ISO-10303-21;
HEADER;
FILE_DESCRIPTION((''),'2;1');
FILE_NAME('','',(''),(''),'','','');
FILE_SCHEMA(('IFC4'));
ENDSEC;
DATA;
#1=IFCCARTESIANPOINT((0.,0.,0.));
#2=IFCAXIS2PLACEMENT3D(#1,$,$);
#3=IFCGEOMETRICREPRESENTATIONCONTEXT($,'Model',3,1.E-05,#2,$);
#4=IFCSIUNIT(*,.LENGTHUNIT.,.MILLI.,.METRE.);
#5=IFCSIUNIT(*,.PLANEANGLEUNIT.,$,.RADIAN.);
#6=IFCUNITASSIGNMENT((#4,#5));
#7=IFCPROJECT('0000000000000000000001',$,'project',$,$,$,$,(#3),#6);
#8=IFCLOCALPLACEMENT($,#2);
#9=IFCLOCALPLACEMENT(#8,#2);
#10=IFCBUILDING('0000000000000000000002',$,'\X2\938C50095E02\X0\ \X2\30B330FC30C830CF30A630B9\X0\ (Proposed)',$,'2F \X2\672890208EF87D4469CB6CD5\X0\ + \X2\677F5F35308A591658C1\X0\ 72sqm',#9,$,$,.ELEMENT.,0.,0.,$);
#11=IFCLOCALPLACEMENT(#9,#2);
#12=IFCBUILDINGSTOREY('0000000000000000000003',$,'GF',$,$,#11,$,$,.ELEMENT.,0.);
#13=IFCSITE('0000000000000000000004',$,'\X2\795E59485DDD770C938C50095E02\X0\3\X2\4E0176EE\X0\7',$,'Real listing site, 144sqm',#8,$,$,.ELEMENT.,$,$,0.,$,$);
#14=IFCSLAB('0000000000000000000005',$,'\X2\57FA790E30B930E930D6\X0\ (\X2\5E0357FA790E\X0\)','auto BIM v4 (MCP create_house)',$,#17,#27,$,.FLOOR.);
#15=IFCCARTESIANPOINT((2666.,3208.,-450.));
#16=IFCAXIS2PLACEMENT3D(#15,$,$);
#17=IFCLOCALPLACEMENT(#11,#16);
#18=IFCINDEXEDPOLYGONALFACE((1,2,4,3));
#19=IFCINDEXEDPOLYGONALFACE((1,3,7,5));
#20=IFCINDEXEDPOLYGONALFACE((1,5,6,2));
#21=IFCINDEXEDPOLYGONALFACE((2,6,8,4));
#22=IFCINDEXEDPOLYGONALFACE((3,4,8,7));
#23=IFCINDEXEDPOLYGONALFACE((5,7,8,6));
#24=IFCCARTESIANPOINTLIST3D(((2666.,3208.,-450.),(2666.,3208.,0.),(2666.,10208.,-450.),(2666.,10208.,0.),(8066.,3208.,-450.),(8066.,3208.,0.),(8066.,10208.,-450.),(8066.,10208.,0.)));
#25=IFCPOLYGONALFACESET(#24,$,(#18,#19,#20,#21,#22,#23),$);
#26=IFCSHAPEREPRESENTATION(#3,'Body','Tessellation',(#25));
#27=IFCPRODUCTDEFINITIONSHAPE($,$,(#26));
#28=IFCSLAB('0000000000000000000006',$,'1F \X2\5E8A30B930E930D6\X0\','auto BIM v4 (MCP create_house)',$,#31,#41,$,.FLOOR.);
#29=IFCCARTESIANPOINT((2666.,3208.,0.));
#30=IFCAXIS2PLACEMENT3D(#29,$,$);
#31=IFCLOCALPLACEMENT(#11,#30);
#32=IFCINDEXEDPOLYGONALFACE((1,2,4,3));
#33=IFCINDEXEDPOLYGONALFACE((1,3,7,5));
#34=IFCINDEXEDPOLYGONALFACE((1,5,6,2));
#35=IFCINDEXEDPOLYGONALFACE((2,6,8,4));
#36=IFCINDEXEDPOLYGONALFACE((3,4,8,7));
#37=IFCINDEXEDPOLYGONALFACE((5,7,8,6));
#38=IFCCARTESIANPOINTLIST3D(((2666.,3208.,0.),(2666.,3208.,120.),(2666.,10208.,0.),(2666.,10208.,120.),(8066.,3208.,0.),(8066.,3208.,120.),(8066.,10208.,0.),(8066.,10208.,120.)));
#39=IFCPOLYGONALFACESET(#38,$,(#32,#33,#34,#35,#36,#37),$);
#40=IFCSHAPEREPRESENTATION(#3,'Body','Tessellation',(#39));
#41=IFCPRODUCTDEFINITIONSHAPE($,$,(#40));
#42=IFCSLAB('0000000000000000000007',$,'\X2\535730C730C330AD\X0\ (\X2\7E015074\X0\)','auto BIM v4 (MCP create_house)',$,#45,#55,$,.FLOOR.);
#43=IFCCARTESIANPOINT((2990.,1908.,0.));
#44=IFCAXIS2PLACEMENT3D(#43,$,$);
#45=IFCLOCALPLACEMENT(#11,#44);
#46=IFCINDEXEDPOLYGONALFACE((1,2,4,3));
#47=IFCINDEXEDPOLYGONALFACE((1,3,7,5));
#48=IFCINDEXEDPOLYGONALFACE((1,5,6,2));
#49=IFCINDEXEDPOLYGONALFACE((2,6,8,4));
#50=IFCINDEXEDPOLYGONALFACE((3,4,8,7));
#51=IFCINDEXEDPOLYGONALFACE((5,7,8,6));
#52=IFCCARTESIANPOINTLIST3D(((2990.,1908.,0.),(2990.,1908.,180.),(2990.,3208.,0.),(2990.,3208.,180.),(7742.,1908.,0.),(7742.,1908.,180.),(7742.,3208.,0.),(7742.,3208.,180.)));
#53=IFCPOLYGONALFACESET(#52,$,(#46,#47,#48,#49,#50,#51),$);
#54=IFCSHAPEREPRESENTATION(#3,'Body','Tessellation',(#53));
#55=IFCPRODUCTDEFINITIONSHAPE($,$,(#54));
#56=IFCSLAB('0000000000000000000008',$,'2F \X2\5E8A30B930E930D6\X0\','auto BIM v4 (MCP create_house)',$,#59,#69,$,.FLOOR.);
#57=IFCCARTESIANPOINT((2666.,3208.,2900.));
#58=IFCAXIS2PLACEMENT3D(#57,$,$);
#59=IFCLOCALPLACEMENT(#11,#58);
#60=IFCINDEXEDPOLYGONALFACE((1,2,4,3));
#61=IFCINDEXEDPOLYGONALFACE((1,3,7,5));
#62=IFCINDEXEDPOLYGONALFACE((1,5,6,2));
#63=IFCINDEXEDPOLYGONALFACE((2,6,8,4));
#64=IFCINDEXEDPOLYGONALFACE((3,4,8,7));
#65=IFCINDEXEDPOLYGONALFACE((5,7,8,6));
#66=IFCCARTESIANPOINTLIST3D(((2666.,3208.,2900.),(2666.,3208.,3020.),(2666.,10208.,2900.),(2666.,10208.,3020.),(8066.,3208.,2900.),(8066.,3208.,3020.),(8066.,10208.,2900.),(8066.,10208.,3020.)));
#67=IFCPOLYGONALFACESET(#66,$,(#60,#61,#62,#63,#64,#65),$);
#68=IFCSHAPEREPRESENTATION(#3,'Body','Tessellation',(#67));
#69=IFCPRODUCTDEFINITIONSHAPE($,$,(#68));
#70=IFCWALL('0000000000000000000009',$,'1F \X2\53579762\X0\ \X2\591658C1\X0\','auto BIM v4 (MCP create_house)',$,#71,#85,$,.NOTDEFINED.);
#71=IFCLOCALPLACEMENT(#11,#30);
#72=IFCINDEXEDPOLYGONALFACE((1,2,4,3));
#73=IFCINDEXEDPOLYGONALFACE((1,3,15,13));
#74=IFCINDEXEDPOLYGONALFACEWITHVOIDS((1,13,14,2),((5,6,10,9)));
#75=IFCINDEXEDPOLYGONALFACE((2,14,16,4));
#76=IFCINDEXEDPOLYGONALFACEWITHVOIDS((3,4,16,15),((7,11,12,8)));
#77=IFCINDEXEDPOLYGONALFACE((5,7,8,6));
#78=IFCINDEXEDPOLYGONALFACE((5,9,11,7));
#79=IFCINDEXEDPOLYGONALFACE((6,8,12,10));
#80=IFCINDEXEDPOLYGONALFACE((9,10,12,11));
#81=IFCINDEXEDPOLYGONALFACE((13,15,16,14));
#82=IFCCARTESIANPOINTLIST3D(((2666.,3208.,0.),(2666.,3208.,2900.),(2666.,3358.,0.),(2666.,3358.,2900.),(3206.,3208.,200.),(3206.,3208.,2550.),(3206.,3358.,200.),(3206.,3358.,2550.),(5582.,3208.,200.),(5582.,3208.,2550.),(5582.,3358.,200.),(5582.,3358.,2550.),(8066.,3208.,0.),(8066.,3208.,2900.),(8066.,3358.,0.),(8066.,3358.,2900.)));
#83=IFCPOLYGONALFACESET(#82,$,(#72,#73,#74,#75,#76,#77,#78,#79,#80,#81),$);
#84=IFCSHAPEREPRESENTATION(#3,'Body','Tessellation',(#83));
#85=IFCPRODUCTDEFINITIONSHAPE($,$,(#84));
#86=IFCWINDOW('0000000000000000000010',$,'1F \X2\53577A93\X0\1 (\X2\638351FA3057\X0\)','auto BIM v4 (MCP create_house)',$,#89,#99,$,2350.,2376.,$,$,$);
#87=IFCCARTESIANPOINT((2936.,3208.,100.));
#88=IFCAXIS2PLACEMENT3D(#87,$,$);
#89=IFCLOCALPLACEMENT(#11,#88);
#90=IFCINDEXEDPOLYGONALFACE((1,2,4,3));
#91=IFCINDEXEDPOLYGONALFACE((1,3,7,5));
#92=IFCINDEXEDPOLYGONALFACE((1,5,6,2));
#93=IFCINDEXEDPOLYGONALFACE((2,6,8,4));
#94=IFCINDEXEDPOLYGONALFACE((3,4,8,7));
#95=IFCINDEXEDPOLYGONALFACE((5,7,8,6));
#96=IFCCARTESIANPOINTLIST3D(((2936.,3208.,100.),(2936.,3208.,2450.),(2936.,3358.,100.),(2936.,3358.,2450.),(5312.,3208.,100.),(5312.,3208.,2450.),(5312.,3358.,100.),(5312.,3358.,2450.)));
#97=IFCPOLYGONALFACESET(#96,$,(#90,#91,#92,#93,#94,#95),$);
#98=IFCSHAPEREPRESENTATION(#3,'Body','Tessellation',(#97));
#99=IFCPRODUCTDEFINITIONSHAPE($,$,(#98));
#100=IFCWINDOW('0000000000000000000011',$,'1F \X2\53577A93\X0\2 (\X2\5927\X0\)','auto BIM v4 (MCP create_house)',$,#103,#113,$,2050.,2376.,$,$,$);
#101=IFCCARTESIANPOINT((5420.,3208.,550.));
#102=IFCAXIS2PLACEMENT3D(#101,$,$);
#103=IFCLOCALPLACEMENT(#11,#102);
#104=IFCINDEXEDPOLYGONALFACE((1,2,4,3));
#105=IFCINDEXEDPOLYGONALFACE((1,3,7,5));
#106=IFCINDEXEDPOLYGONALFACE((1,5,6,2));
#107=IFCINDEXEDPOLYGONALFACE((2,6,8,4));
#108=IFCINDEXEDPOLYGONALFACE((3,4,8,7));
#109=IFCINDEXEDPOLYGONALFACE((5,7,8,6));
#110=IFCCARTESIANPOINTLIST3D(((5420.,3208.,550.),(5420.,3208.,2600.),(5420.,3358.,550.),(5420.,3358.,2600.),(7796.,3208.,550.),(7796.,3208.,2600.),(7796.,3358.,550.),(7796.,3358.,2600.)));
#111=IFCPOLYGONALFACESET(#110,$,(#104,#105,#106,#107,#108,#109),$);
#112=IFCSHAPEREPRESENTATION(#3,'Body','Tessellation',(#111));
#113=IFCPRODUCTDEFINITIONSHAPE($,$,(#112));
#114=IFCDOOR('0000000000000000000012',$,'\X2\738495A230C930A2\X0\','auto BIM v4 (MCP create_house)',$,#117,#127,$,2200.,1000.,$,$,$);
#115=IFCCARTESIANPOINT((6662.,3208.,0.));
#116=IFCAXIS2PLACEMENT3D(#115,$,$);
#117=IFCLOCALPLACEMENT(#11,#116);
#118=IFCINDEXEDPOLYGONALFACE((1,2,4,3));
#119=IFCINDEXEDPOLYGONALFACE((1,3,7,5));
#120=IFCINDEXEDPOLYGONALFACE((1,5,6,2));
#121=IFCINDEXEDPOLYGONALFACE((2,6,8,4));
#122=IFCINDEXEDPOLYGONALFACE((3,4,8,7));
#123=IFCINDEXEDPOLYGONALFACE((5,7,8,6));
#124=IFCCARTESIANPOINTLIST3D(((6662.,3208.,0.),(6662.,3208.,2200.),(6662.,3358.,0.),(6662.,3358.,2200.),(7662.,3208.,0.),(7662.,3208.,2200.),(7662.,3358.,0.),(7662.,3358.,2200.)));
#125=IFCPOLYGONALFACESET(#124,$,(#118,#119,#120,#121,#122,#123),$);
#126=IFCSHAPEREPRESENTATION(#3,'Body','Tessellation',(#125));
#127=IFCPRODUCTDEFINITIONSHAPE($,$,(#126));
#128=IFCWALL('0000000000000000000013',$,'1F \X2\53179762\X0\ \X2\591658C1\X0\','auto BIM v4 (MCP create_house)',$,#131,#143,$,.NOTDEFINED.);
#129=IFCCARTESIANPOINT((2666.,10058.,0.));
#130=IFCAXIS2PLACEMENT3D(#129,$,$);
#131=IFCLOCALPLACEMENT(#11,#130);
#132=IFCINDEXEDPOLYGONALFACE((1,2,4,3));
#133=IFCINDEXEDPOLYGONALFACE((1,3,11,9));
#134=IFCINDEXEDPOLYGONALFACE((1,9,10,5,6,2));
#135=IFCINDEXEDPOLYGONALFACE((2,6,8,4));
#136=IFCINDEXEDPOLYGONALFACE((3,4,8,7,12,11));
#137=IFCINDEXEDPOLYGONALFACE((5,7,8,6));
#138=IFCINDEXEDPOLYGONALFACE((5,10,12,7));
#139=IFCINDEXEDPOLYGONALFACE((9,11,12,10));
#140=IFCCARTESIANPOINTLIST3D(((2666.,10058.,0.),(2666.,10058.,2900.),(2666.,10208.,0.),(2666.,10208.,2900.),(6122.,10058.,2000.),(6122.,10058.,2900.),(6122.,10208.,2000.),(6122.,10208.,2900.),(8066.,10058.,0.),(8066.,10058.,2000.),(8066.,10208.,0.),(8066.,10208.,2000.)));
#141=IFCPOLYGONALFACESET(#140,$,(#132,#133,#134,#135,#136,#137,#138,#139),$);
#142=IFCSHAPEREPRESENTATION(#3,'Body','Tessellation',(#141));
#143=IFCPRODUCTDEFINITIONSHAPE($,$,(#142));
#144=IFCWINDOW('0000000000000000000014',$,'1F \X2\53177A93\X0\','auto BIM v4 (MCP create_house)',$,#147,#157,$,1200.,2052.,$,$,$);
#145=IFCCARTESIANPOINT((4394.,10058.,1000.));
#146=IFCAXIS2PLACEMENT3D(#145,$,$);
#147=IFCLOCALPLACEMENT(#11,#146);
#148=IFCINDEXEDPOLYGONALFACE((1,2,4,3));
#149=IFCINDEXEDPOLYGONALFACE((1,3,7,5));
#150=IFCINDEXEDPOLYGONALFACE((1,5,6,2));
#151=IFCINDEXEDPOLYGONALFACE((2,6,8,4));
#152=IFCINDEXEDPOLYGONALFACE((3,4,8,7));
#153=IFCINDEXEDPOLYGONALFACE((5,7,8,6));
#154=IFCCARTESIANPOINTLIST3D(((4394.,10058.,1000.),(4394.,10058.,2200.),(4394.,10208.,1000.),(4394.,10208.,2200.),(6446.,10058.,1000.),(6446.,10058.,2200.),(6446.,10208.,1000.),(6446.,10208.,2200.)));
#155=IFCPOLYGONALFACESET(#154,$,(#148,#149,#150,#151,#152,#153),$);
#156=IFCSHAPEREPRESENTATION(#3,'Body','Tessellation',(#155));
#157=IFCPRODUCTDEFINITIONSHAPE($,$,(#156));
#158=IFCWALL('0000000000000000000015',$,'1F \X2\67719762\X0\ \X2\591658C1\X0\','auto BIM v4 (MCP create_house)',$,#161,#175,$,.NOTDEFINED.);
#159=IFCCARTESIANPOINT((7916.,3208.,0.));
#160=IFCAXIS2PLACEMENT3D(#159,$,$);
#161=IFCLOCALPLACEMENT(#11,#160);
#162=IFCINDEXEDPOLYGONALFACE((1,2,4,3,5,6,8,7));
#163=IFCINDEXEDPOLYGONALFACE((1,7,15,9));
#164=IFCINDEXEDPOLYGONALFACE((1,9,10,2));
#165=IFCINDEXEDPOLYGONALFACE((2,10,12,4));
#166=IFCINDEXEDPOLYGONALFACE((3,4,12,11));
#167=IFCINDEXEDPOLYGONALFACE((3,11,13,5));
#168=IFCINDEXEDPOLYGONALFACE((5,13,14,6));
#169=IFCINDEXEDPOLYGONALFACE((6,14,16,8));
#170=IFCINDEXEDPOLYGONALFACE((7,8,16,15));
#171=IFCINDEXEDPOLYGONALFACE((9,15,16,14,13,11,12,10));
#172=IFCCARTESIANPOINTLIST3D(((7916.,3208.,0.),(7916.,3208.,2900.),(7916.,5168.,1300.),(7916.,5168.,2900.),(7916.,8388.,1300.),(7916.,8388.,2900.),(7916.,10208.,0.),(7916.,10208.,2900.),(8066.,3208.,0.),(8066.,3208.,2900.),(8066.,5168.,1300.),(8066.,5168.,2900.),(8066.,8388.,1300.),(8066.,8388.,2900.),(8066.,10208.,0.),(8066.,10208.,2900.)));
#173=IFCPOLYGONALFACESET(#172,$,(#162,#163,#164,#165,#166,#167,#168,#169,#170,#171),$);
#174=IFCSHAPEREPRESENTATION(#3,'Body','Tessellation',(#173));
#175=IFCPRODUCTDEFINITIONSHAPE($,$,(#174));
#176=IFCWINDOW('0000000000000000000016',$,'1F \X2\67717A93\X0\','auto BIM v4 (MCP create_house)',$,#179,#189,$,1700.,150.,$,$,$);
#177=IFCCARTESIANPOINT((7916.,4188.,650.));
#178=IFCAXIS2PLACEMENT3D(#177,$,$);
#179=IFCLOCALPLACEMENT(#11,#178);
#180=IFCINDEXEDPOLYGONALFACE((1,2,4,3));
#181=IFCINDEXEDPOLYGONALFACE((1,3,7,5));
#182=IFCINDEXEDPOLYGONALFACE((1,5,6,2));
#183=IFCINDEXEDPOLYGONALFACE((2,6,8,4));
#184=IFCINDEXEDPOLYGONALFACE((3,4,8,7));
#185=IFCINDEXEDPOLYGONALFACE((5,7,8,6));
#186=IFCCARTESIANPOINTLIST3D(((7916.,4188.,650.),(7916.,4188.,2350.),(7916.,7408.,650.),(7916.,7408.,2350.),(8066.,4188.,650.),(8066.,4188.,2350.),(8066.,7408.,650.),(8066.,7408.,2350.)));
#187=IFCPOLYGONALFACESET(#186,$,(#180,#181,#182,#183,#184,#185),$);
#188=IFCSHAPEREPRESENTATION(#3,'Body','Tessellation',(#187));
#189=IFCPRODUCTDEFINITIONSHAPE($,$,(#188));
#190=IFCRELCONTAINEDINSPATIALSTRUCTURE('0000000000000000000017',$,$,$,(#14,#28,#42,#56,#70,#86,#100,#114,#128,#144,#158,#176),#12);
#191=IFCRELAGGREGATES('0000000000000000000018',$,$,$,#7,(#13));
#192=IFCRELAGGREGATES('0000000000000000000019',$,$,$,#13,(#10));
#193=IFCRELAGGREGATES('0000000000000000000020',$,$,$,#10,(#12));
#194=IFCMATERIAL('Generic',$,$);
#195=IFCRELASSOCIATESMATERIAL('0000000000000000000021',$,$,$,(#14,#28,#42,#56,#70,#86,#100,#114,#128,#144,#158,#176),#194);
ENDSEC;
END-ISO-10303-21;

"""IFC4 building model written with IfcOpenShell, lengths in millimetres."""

from ifc_helpers import new_model, si_unit, frame, frame_2d, origin, place, context, project, spatial, rectangle, extrude, material, element, fill, save


model = new_model("IFC4")

# Units and contexts
model_context = context("Model", 3, precision=1e-05, world=origin())
ifc_project = project(units=[si_unit("LENGTHUNIT", "METRE", prefix="MILLI"), si_unit("PLANEANGLEUNIT", "RADIAN")], contexts=[model_context])

# Site, building, storey
site_placement = place(None, origin())
site = spatial("IfcSite", under=ifc_project, at=site_placement, Name="神奈川県鎌倉市3丁目7", ObjectType="Real listing site, 144sqm", CompositionType="ELEMENT", RefElevation=0.0)
building_placement = place(site_placement, origin())
building = spatial("IfcBuilding", under=site, at=building_placement, Name="鎌倉市 コートハウス (Proposed)", ObjectType="2F 木造軸組構法 + 板張り外壁 72sqm", CompositionType="ELEMENT", ElevationOfRefHeight=0.0, ElevationOfTerrain=0.0)
storey_placement = place(building_placement, origin())
storey = spatial("IfcBuildingStorey", under=building, at=storey_placement, Name="GF", CompositionType="ELEMENT", Elevation=0.0)

# Slabs
ifc_material = material(Name="Generic")
slab_1_placement = place(storey_placement, frame((2666.0, 3208.0, -450.0)))
element("IfcSlab", 1, at=slab_1_placement, inside=storey, material=ifc_material, Name="基礎スラブ (布基礎)", Description="auto BIM v4 (MCP create_house)", PredefinedType="FLOOR", context=model_context, shape_type="SweptSolid", body=[
    extrude(rectangle(XDim=5400.0, YDim=7000.0, at=frame_2d((2700.0, 3500.0))), frame((2666.0, 3208.0, -450.0)), (0.0, 0.0, 1.0), 450.0),
])
slab_2_placement = place(storey_placement, frame((2666.0, 3208.0, 0.0)))
element("IfcSlab", 2, at=slab_2_placement, inside=storey, material=ifc_material, Name="1F 床スラブ", Description="auto BIM v4 (MCP create_house)", PredefinedType="FLOOR", context=model_context, shape_type="SweptSolid", body=[
    extrude(rectangle(XDim=5400.0, YDim=7000.0, at=frame_2d((2700.0, 3500.0))), frame((2666.0, 3208.0, 0.0)), (0.0, 0.0, 1.0), 120.0),
])
slab_3_placement = place(storey_placement, frame((2990.0, 1908.0, 0.0)))
element("IfcSlab", 3, at=slab_3_placement, inside=storey, material=ifc_material, Name="南デッキ (縁側)", Description="auto BIM v4 (MCP create_house)", PredefinedType="FLOOR", context=model_context, shape_type="SweptSolid", body=[
    extrude(rectangle(XDim=4752.0, YDim=1300.0, at=frame_2d((2376.0, 650.0))), frame((2990.0, 1908.0, 0.0)), (0.0, 0.0, 1.0), 180.0),
])
slab_4_placement = place(storey_placement, frame((2666.0, 3208.0, 2900.0)))
element("IfcSlab", 4, at=slab_4_placement, inside=storey, material=ifc_material, Name="2F 床スラブ", Description="auto BIM v4 (MCP create_house)", PredefinedType="FLOOR", context=model_context, shape_type="SweptSolid", body=[
    extrude(rectangle(XDim=5400.0, YDim=7000.0, at=frame_2d((2700.0, 3500.0))), frame((2666.0, 3208.0, 2900.0)), (0.0, 0.0, 1.0), 120.0),
])

# Wall, openings, windows, door
wall_1_placement = place(storey_placement, frame((2666.0, 3208.0, 0.0)))
wall_1 = element("IfcWall", 5, at=wall_1_placement, inside=storey, material=ifc_material, Name="1F 南面 外壁", Description="auto BIM v4 (MCP create_house)", PredefinedType="NOTDEFINED", context=model_context, shape_type="SweptSolid", body=[
    extrude(rectangle(XDim=5400.0, YDim=150.0, at=frame_2d((2700.0, 75.0))), frame((2666.0, 3208.0, 0.0)), (0.0, 0.0, 1.0), 2900.0),
])
opening_1_placement = place(storey_placement, frame((2936.0, 3208.0, 100.0)))
opening_1 = element("IfcOpeningElement", 6, at=opening_1_placement, cuts=wall_1, PredefinedType="NOTDEFINED", context=model_context, shape_type="SweptSolid", body=[
    extrude(rectangle(XDim=2376.0, YDim=150.0, at=frame_2d((1188.0, 75.0))), frame((2936.0, 3208.0, 100.0)), (0.0, 0.0, 1.0), 2350.0),
])
opening_2_placement = place(storey_placement, frame((5420.0, 3208.0, 550.0)))
opening_2 = element("IfcOpeningElement", 7, at=opening_2_placement, cuts=wall_1, PredefinedType="NOTDEFINED", context=model_context, shape_type="SweptSolid", body=[
    extrude(rectangle(XDim=2376.0, YDim=150.0, at=frame_2d((1188.0, 75.0))), frame((5420.0, 3208.0, 550.0)), (0.0, 0.0, 1.0), 2050.0),
])
opening_3_placement = place(storey_placement, frame((6662.0, 3208.0, 0.0)))
opening_3 = element("IfcOpeningElement", 8, at=opening_3_placement, cuts=wall_1, PredefinedType="NOTDEFINED", context=model_context, shape_type="SweptSolid", body=[
    extrude(rectangle(XDim=1000.0, YDim=150.0, at=frame_2d((500.0, 75.0))), frame((6662.0, 3208.0, 0.0)), (0.0, 0.0, 1.0), 2200.0),
])
window_1_placement = place(storey_placement, frame((2936.0, 3208.0, 100.0)))
window_1 = element("IfcWindow", 9, at=window_1_placement, inside=storey, material=ifc_material, Name="1F 南窓1 (掃出し)", Description="auto BIM v4 (MCP create_house)", OverallHeight=2350.0, OverallWidth=2376.0, context=model_context, shape_type="SweptSolid", body=[
    extrude(rectangle(XDim=2376.0, YDim=150.0, at=frame_2d((1188.0, 75.0))), frame((2936.0, 3208.0, 100.0)), (0.0, 0.0, 1.0), 2350.0),
])
fill(opening_1, window_1)
window_2_placement = place(storey_placement, frame((5420.0, 3208.0, 550.0)))
window_2 = element("IfcWindow", 10, at=window_2_placement, inside=storey, material=ifc_material, Name="1F 南窓2 (大)", Description="auto BIM v4 (MCP create_house)", OverallHeight=2050.0, OverallWidth=2376.0, context=model_context, shape_type="SweptSolid", body=[
    extrude(rectangle(XDim=2376.0, YDim=150.0, at=frame_2d((1188.0, 75.0))), frame((5420.0, 3208.0, 550.0)), (0.0, 0.0, 1.0), 2050.0),
])
fill(opening_2, window_2)
door_1_placement = place(storey_placement, frame((6662.0, 3208.0, 0.0)))
door_1 = element("IfcDoor", 11, at=door_1_placement, inside=storey, material=ifc_material, Name="玄関ドア", Description="auto BIM v4 (MCP create_house)", OverallHeight=2200.0, OverallWidth=1000.0, context=model_context, shape_type="SweptSolid", body=[
    extrude(rectangle(XDim=1000.0, YDim=150.0, at=frame_2d((500.0, 75.0))), frame((6662.0, 3208.0, 0.0)), (0.0, 0.0, 1.0), 2200.0),
])
fill(opening_3, door_1)

# Walls, openings, windows
wall_2_placement = place(storey_placement, frame((2666.0, 10058.0, 0.0)))
wall_2 = element("IfcWall", 12, at=wall_2_placement, inside=storey, material=ifc_material, Name="1F 北面 外壁", Description="auto BIM v4 (MCP create_house)", PredefinedType="NOTDEFINED", context=model_context, shape_type="SweptSolid", body=[
    extrude(rectangle(XDim=5400.0, YDim=150.0, at=frame_2d((2700.0, 75.0))), frame((2666.0, 10058.0, 0.0)), (0.0, 0.0, 1.0), 2900.0),
])
opening_4_placement = place(storey_placement, frame((4394.0, 10058.0, 1000.0)))
opening_4 = element("IfcOpeningElement", 13, at=opening_4_placement, cuts=wall_2, PredefinedType="NOTDEFINED", context=model_context, shape_type="SweptSolid", body=[
    extrude(rectangle(XDim=2052.0, YDim=150.0, at=frame_2d((1026.0, 75.0))), frame((4394.0, 10058.0, 1000.0)), (0.0, 0.0, 1.0), 1200.0),
])
window_3_placement = place(storey_placement, frame((4394.0, 10058.0, 1000.0)))
window_3 = element("IfcWindow", 14, at=window_3_placement, inside=storey, material=ifc_material, Name="1F 北窓", Description="auto BIM v4 (MCP create_house)", OverallHeight=1200.0, OverallWidth=2052.0, context=model_context, shape_type="SweptSolid", body=[
    extrude(rectangle(XDim=2052.0, YDim=150.0, at=frame_2d((1026.0, 75.0))), frame((4394.0, 10058.0, 1000.0)), (0.0, 0.0, 1.0), 1200.0),
])
fill(opening_4, window_3)
wall_3_placement = place(storey_placement, frame((7916.0, 3208.0, 0.0)))
wall_3 = element("IfcWall", 15, at=wall_3_placement, inside=storey, material=ifc_material, Name="1F 東面 外壁", Description="auto BIM v4 (MCP create_house)", PredefinedType="NOTDEFINED", context=model_context, shape_type="SweptSolid", body=[
    extrude(rectangle(XDim=150.0, YDim=7000.0, at=frame_2d((75.0, 3500.0))), frame((7916.0, 3208.0, 0.0)), (0.0, 0.0, 1.0), 2900.0),
])
opening_5_placement = place(storey_placement, frame((7916.0, 4188.0, 650.0)))
opening_5 = element("IfcOpeningElement", 16, at=opening_5_placement, cuts=wall_3, PredefinedType="NOTDEFINED", context=model_context, shape_type="SweptSolid", body=[
    extrude(rectangle(XDim=150.0, YDim=3220.0, at=frame_2d((75.0, 1610.0))), frame((7916.0, 4188.0, 650.0)), (0.0, 0.0, 1.0), 1700.0),
])
window_4_placement = place(storey_placement, frame((7916.0, 4188.0, 650.0)))
window_4 = element("IfcWindow", 17, at=window_4_placement, inside=storey, material=ifc_material, Name="1F 東窓", Description="auto BIM v4 (MCP create_house)", OverallHeight=1700.0, OverallWidth=150.0, context=model_context, shape_type="SweptSolid", body=[
    extrude(rectangle(XDim=150.0, YDim=3220.0, at=frame_2d((75.0, 1610.0))), frame((7916.0, 4188.0, 650.0)), (0.0, 0.0, 1.0), 1700.0),
])
fill(opening_5, window_4)

save(model, "model.ifc")
